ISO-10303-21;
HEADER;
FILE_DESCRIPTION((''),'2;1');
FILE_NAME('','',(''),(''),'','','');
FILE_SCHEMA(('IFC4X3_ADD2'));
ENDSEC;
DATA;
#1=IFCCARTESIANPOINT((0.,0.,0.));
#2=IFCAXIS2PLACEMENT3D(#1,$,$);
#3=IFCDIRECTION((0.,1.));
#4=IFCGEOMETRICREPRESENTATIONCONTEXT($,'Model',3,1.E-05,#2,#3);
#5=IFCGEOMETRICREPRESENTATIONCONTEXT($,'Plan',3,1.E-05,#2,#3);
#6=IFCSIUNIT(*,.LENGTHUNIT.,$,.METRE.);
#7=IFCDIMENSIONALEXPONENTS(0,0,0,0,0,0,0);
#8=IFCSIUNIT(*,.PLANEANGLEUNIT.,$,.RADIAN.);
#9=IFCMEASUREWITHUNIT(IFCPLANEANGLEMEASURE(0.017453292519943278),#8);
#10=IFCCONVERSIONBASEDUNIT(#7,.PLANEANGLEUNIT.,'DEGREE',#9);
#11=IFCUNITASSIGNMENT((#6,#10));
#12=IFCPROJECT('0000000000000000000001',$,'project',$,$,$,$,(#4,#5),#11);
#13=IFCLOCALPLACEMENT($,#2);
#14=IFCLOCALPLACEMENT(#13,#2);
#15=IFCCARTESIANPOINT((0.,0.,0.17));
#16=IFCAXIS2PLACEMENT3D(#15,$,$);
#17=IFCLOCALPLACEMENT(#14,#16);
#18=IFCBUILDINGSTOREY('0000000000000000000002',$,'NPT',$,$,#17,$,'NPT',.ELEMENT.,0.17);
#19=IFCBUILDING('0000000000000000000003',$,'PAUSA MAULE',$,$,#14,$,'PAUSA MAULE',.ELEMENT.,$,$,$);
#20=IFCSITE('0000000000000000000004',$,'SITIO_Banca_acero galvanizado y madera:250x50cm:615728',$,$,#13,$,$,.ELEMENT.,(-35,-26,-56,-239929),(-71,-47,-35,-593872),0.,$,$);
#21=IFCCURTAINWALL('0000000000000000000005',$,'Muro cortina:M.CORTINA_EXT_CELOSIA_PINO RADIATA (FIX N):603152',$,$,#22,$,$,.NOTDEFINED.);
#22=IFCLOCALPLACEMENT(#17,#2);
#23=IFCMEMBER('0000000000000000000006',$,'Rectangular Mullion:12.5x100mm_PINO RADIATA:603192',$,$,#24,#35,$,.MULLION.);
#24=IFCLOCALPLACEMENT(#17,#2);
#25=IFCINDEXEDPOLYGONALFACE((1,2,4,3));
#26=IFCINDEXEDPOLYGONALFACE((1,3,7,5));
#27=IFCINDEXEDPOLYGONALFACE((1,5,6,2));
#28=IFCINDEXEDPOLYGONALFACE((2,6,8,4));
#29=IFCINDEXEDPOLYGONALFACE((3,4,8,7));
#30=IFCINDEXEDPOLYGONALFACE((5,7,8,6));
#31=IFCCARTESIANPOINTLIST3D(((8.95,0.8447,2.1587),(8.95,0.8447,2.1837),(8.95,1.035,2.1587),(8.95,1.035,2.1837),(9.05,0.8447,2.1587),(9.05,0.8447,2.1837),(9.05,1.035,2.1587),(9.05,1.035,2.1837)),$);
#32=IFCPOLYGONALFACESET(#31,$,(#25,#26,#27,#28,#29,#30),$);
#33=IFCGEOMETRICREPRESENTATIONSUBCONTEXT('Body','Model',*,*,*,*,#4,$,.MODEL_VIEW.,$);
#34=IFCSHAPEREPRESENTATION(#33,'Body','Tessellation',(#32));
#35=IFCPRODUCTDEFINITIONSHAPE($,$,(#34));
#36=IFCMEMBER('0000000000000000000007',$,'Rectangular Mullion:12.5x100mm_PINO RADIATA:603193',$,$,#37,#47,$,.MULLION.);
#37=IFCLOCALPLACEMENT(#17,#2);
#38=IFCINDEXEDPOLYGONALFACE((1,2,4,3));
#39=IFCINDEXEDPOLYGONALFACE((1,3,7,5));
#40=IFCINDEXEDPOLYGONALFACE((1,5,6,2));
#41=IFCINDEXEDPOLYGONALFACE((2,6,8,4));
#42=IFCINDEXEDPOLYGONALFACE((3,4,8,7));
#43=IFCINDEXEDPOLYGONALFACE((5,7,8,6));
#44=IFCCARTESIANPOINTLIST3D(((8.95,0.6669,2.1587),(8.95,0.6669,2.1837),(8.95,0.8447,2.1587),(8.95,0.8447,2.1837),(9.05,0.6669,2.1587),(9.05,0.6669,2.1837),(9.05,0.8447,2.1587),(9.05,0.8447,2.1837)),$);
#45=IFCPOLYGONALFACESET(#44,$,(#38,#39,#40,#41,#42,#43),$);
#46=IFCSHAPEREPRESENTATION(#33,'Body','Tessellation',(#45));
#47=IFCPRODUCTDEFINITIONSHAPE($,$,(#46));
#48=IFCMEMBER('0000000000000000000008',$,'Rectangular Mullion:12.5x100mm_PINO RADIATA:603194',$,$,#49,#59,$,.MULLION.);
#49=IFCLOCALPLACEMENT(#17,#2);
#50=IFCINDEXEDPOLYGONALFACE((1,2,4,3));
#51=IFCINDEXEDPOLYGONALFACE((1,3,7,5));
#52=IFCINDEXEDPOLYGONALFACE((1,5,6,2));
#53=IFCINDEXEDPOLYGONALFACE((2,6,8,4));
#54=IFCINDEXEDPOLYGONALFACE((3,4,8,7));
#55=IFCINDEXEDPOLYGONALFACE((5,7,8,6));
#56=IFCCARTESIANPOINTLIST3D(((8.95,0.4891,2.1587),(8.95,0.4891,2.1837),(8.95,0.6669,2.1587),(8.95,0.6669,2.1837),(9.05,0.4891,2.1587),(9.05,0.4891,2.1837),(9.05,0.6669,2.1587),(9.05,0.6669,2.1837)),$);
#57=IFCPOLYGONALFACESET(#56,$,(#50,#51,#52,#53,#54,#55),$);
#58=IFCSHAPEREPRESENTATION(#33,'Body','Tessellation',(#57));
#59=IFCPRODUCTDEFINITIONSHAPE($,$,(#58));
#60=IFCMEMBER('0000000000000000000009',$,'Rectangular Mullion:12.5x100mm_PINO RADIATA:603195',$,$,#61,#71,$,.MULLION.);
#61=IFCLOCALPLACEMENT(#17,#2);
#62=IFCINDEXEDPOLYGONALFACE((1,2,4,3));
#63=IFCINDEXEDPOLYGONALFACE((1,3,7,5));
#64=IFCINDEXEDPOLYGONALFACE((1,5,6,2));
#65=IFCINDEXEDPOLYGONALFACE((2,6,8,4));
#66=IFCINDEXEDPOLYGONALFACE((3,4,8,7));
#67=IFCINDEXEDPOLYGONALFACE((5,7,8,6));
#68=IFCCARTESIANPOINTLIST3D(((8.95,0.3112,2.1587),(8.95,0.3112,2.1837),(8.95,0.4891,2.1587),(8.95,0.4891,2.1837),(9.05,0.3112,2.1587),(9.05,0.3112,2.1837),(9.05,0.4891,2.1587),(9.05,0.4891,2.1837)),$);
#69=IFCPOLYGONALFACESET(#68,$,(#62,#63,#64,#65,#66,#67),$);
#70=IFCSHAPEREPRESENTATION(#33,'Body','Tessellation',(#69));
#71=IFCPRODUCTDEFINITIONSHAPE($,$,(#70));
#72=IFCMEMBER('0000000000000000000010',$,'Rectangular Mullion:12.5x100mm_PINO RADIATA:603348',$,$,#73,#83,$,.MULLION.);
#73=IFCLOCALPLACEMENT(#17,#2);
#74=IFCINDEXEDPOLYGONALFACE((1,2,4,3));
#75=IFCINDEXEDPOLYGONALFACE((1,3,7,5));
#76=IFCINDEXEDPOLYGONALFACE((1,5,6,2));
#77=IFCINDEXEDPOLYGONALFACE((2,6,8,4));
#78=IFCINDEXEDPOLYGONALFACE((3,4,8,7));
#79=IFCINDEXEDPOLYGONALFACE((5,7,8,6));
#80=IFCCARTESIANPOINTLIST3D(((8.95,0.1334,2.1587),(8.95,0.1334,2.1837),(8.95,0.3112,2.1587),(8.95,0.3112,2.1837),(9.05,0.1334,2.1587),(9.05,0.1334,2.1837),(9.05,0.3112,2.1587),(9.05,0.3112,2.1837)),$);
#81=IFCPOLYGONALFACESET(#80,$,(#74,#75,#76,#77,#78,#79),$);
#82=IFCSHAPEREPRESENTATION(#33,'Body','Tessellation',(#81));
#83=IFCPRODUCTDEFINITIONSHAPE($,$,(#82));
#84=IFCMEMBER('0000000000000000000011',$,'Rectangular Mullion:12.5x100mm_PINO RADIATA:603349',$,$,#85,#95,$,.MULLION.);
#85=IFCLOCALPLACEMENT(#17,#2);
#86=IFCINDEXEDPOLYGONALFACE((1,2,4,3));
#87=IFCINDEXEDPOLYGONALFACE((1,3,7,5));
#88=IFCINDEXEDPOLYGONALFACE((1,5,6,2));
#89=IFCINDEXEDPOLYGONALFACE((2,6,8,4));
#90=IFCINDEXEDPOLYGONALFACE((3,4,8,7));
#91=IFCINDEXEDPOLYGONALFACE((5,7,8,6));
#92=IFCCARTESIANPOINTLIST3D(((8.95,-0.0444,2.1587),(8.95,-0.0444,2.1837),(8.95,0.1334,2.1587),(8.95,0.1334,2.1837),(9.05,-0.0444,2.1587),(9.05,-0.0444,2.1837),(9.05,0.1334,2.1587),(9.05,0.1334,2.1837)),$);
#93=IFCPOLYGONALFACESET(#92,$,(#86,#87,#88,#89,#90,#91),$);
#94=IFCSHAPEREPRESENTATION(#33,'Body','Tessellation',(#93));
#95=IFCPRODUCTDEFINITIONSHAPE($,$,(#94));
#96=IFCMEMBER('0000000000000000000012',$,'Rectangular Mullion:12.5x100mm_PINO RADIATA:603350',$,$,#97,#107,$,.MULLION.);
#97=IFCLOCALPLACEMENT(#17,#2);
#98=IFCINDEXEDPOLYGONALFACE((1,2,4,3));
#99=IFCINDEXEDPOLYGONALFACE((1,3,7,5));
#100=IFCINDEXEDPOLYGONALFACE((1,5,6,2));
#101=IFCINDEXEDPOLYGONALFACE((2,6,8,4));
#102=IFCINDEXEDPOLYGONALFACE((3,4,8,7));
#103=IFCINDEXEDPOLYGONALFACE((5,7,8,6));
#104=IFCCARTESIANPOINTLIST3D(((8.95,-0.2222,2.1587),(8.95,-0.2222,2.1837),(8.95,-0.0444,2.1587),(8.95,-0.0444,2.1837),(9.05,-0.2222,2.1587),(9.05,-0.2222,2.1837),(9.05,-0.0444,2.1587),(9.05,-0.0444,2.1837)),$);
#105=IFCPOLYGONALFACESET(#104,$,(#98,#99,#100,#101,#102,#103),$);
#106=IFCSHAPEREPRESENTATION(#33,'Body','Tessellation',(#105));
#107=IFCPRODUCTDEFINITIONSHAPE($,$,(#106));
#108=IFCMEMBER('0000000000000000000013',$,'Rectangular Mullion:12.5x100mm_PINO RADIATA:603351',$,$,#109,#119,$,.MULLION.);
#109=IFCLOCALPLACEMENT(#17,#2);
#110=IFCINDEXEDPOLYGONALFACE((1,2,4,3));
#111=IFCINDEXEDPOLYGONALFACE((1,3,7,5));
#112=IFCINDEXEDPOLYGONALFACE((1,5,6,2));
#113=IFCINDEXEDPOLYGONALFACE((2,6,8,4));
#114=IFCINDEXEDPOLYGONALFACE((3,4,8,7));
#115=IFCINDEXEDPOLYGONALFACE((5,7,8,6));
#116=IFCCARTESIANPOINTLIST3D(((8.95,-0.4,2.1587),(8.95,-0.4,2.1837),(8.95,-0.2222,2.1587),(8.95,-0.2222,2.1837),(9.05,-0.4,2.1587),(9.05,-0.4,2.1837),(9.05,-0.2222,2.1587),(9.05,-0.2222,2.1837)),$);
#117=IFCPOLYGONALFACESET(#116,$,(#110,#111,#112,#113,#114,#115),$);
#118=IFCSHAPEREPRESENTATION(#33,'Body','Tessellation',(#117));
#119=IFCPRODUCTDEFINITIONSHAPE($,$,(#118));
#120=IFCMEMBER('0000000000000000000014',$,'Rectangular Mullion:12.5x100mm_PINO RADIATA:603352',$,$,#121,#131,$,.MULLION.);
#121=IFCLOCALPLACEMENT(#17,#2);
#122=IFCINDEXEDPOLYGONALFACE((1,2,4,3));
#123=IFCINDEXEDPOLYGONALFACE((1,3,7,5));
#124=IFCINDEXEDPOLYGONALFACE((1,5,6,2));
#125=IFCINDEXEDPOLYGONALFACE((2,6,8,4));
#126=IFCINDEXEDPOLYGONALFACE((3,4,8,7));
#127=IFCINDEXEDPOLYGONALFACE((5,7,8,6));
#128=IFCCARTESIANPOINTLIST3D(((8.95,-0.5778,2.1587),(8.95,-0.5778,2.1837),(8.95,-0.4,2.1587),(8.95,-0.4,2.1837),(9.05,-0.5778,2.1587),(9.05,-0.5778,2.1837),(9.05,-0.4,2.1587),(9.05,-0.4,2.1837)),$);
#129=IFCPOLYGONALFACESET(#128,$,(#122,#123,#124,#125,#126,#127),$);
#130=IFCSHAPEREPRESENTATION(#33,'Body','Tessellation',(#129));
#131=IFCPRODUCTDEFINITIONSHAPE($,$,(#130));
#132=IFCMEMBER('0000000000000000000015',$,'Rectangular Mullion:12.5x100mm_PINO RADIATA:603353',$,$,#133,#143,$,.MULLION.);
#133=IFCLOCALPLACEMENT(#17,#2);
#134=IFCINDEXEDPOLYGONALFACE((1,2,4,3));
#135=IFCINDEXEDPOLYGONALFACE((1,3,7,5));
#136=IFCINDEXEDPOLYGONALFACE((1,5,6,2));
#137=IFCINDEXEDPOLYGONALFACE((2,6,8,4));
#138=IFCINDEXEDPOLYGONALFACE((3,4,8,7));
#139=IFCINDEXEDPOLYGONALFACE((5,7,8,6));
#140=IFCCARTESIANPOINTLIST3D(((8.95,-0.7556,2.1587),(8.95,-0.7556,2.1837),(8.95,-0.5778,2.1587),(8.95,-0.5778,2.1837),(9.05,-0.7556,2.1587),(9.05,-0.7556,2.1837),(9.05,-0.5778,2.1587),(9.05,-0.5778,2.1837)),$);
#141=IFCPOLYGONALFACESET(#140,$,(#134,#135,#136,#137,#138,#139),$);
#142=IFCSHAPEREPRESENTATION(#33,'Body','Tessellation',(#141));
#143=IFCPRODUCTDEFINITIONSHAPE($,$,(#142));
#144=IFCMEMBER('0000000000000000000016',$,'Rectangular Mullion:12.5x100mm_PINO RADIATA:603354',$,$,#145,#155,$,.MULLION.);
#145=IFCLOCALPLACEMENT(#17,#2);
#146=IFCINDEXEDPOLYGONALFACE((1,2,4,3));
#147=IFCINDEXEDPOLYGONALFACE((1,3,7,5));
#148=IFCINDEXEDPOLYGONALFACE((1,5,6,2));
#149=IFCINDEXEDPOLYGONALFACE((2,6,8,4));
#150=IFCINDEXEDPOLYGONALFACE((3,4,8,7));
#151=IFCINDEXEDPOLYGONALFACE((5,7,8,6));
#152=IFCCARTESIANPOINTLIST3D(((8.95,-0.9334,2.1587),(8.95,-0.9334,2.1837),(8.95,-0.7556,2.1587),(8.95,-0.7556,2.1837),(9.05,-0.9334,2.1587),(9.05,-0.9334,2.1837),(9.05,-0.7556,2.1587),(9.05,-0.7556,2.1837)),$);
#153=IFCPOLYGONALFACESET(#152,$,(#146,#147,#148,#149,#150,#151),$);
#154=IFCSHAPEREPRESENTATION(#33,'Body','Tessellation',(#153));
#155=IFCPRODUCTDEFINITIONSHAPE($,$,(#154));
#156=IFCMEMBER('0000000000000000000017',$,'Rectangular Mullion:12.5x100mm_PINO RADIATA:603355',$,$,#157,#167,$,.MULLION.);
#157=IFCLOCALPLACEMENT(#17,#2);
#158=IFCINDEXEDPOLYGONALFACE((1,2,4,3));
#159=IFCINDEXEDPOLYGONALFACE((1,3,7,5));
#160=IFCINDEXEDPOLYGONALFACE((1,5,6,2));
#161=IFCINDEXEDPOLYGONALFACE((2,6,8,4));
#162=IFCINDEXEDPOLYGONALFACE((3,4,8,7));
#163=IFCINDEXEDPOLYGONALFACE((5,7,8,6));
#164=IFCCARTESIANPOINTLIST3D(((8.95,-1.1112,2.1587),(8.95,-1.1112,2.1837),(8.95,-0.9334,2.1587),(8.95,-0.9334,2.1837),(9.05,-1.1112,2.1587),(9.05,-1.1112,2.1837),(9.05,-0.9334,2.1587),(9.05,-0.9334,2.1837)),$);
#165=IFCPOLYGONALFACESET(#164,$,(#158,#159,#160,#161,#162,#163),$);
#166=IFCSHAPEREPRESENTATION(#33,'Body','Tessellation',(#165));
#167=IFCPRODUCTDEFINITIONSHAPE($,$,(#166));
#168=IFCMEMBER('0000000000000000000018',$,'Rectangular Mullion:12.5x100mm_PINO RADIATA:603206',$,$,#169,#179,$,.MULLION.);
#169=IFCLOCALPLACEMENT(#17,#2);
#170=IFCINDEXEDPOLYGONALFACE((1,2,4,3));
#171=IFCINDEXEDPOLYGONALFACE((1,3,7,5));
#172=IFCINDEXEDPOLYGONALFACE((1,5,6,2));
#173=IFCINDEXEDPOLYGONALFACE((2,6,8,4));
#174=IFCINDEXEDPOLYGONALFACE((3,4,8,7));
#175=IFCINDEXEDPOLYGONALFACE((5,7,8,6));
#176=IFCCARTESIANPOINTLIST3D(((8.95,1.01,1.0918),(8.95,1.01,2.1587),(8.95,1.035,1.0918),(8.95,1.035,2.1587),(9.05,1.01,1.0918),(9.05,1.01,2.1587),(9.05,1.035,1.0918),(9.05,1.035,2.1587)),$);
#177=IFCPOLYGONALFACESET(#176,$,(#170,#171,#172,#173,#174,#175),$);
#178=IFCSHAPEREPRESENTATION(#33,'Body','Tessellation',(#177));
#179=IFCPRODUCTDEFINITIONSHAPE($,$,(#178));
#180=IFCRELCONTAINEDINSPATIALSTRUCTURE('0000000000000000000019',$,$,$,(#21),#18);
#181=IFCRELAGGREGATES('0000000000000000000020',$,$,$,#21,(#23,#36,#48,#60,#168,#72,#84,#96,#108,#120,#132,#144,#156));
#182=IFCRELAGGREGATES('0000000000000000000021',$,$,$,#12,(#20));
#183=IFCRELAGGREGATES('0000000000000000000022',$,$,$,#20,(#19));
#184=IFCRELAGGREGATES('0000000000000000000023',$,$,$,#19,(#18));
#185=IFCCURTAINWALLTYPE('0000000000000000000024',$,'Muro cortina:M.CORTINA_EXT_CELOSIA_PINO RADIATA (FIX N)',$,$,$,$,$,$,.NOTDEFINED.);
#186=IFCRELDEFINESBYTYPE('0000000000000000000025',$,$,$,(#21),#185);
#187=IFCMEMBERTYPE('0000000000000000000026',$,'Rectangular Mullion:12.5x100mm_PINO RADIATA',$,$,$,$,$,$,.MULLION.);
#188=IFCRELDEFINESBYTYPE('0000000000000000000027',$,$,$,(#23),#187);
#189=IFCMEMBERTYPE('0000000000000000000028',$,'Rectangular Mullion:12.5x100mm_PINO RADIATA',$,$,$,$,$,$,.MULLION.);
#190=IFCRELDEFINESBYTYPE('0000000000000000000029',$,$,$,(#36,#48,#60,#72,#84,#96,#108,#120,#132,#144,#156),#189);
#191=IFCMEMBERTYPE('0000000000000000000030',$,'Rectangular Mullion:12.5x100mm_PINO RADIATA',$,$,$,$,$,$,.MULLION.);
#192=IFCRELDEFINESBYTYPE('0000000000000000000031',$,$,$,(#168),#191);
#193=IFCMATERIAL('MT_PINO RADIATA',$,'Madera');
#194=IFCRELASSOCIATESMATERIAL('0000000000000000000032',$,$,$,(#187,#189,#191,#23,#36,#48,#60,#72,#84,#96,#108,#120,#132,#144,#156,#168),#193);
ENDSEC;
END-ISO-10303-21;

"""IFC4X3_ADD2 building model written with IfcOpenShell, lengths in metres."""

from ifc_helpers import new_model, entity, si_unit, converted_unit, direction, frame, frame_2d, origin, place, context, subcontext, project, spatial, rectangle, extrude, source, transform, mapped, material, material_profile, profile_set, profile_usage, type_object, type_shapes, element, aggregate, save


model = new_model("IFC4X3_ADD2")

# Units and contexts
model_context = context("Model", 3, precision=1e-05, world=origin(), true_north=direction((0.0, 1.0)))
plan_context = context("Plan", 3, precision=1e-05, world=origin(), true_north=direction((0.0, 1.0)))
body_context = subcontext(model_context, "Body", "Model", "MODEL_VIEW")
ifc_project = project(units=[si_unit("LENGTHUNIT", "METRE"), converted_unit("PLANEANGLEUNIT", "DEGREE", entity("IfcPlaneAngleMeasure", 0.017453292519943278), si_unit("PLANEANGLEUNIT", "RADIAN"), dimensions=[0, 0, 0, 0, 0, 0, 0])], contexts=[model_context, plan_context])

# Site, building, storey
site_placement = place(None, origin())
site = spatial("IfcSite", under=ifc_project, at=site_placement, Name="SITIO_Banca_acero galvanizado y madera:250x50cm:615728", CompositionType="ELEMENT", RefLatitude=(-35, -26, -56, -239929), RefLongitude=(-71, -47, -35, -593872), RefElevation=0.0)
building_placement = place(site_placement, origin())
building = spatial("IfcBuilding", under=site, at=building_placement, Name="PAUSA MAULE", LongName="PAUSA MAULE", CompositionType="ELEMENT")
storey_placement = place(building_placement, frame((0.0, 0.0, 0.17)))
storey = spatial("IfcBuildingStorey", under=building, at=storey_placement, Name="NPT", LongName="NPT", CompositionType="ELEMENT", Elevation=0.17)

# Curtain wall, members
curtain_wall_type = type_object("IfcCurtainWallType", Name="Muro cortina:M.CORTINA_EXT_CELOSIA_PINO RADIATA (FIX N)", PredefinedType="NOTDEFINED")
curtain_wall_placement = place(storey_placement, frame((0.0, 0.0, -0.17)))
curtain_wall = element("IfcCurtainWall", 1, at=curtain_wall_placement, inside=storey, type_object=curtain_wall_type, Name="Muro cortina:M.CORTINA_EXT_CELOSIA_PINO RADIATA (FIX N):603152", PredefinedType="NOTDEFINED")
ifc_material = material(Name="MT_PINO RADIATA", Category="Madera")
ifc_material_profile = material_profile(ifc_material, rectangle(XDim=0.025, YDim=0.1, at=frame_2d((0.0, 0.0), x_axis=(1.0, 0.0))), Name="12.5x100mm_PINO RADIATA")
ifc_profile_set = profile_set([ifc_material_profile], Name="12.5x100mm_PINO RADIATA")
ifc_profile_usage = profile_usage(ifc_profile_set)
member_type_1 = type_object("IfcMemberType", Name="Rectangular Mullion:12.5x100mm_PINO RADIATA", PredefinedType="MULLION", material=ifc_profile_set)
shared_shape_1 = source(origin(), body_context, "Body", "SweptSolid", [
    extrude(rectangle(XDim=0.025, YDim=0.1, at=frame_2d((0.0, 0.0), x_axis=(1.0, 0.0))), frame((-0.0125, 0.0, -0.1903), z_axis=(0.0, 0.0, 1.0), x_axis=(-1.0, 0.0, 0.0)), (0.0, 0.0, 1.0), 0.1903),
])
type_shapes(member_type_1, [shared_shape_1])
member_1_placement = place(curtain_wall_placement, frame((9.0, 0.8447, 2.3537), z_axis=(0.0, -1.0, 0.0), x_axis=(0.0, 0.0, 1.0)))
member_1 = element("IfcMember", 2, at=member_1_placement, type_object=member_type_1, material=ifc_profile_usage, Name="Rectangular Mullion:12.5x100mm_PINO RADIATA:603192", PredefinedType="MULLION", context=body_context, shape_type="MappedRepresentation", body=[
    mapped(shared_shape_1, transform((0.0, 0.0, 0.0), scale=1.0)),
])
member_type_2 = type_object("IfcMemberType", Name="Rectangular Mullion:12.5x100mm_PINO RADIATA", PredefinedType="MULLION", material=ifc_profile_set)
shared_shape_2 = source(origin(), body_context, "Body", "SweptSolid", [
    extrude(rectangle(XDim=0.025, YDim=0.1, at=frame_2d((0.0, 0.0), x_axis=(1.0, 0.0))), frame((-0.0125, 0.0, -0.1778), z_axis=(0.0, 0.0, 1.0), x_axis=(-1.0, 0.0, 0.0)), (0.0, 0.0, 1.0), 0.1778),
])
type_shapes(member_type_2, [shared_shape_2])
member_2_placement = place(curtain_wall_placement, frame((9.0, 0.6669, 2.3537), z_axis=(0.0, -1.0, 0.0), x_axis=(0.0, 0.0, 1.0)))
member_2 = element("IfcMember", 3, at=member_2_placement, type_object=member_type_2, material=ifc_profile_usage, Name="Rectangular Mullion:12.5x100mm_PINO RADIATA:603193", PredefinedType="MULLION", context=body_context, shape_type="MappedRepresentation", body=[
    mapped(shared_shape_2, transform((0.0, 0.0, 0.0), scale=1.0)),
])
member_3_placement = place(curtain_wall_placement, frame((9.0, 0.4891, 2.3537), z_axis=(0.0, -1.0, 0.0), x_axis=(0.0, 0.0, 1.0)))
member_3 = element("IfcMember", 4, at=member_3_placement, type_object=member_type_2, material=ifc_profile_usage, Name="Rectangular Mullion:12.5x100mm_PINO RADIATA:603194", PredefinedType="MULLION", context=body_context, shape_type="MappedRepresentation", body=[
    mapped(shared_shape_2, transform((0.0, 0.0, 0.0), scale=1.0)),
])
member_4_placement = place(curtain_wall_placement, frame((9.0, 0.3112, 2.3537), z_axis=(0.0, -1.0, 0.0), x_axis=(0.0, 0.0, 1.0)))
member_4 = element("IfcMember", 5, at=member_4_placement, type_object=member_type_2, material=ifc_profile_usage, Name="Rectangular Mullion:12.5x100mm_PINO RADIATA:603195", PredefinedType="MULLION", context=body_context, shape_type="MappedRepresentation", body=[
    mapped(shared_shape_2, transform((0.0, 0.0, 0.0), scale=1.0)),
])
member_5_placement = place(curtain_wall_placement, frame((9.0, 0.1334, 2.3537), z_axis=(0.0, -1.0, 0.0), x_axis=(0.0, 0.0, 1.0)))
member_5 = element("IfcMember", 6, at=member_5_placement, type_object=member_type_2, material=ifc_profile_usage, Name="Rectangular Mullion:12.5x100mm_PINO RADIATA:603348", PredefinedType="MULLION", context=body_context, shape_type="MappedRepresentation", body=[
    mapped(shared_shape_2, transform((0.0, 0.0, 0.0), scale=1.0)),
])
member_6_placement = place(curtain_wall_placement, frame((9.0, -0.0444, 2.3537), z_axis=(0.0, -1.0, 0.0), x_axis=(0.0, 0.0, 1.0)))
member_6 = element("IfcMember", 7, at=member_6_placement, type_object=member_type_2, material=ifc_profile_usage, Name="Rectangular Mullion:12.5x100mm_PINO RADIATA:603349", PredefinedType="MULLION", context=body_context, shape_type="MappedRepresentation", body=[
    mapped(shared_shape_2, transform((0.0, 0.0, 0.0), scale=1.0)),
])
member_7_placement = place(curtain_wall_placement, frame((9.0, -0.2222, 2.3537), z_axis=(0.0, -1.0, 0.0), x_axis=(0.0, 0.0, 1.0)))
member_7 = element("IfcMember", 8, at=member_7_placement, type_object=member_type_2, material=ifc_profile_usage, Name="Rectangular Mullion:12.5x100mm_PINO RADIATA:603350", PredefinedType="MULLION", context=body_context, shape_type="MappedRepresentation", body=[
    mapped(shared_shape_2, transform((0.0, 0.0, 0.0), scale=1.0)),
])
member_8_placement = place(curtain_wall_placement, frame((9.0, -0.4, 2.3537), z_axis=(0.0, -1.0, 0.0), x_axis=(0.0, 0.0, 1.0)))
member_8 = element("IfcMember", 9, at=member_8_placement, type_object=member_type_2, material=ifc_profile_usage, Name="Rectangular Mullion:12.5x100mm_PINO RADIATA:603351", PredefinedType="MULLION", context=body_context, shape_type="MappedRepresentation", body=[
    mapped(shared_shape_2, transform((0.0, 0.0, 0.0), scale=1.0)),
])
member_9_placement = place(curtain_wall_placement, frame((9.0, -0.5778, 2.3537), z_axis=(0.0, -1.0, 0.0), x_axis=(0.0, 0.0, 1.0)))
member_9 = element("IfcMember", 10, at=member_9_placement, type_object=member_type_2, material=ifc_profile_usage, Name="Rectangular Mullion:12.5x100mm_PINO RADIATA:603352", PredefinedType="MULLION", context=body_context, shape_type="MappedRepresentation", body=[
    mapped(shared_shape_2, transform((0.0, 0.0, 0.0), scale=1.0)),
])
member_10_placement = place(curtain_wall_placement, frame((9.0, -0.7556, 2.3537), z_axis=(0.0, -1.0, 0.0), x_axis=(0.0, 0.0, 1.0)))
member_10 = element("IfcMember", 11, at=member_10_placement, type_object=member_type_2, material=ifc_profile_usage, Name="Rectangular Mullion:12.5x100mm_PINO RADIATA:603353", PredefinedType="MULLION", context=body_context, shape_type="MappedRepresentation", body=[
    mapped(shared_shape_2, transform((0.0, 0.0, 0.0), scale=1.0)),
])
member_11_placement = place(curtain_wall_placement, frame((9.0, -0.9334, 2.3537), z_axis=(0.0, -1.0, 0.0), x_axis=(0.0, 0.0, 1.0)))
member_11 = element("IfcMember", 12, at=member_11_placement, type_object=member_type_2, material=ifc_profile_usage, Name="Rectangular Mullion:12.5x100mm_PINO RADIATA:603354", PredefinedType="MULLION", context=body_context, shape_type="MappedRepresentation", body=[
    mapped(shared_shape_2, transform((0.0, 0.0, 0.0), scale=1.0)),
])
member_12_placement = place(curtain_wall_placement, frame((9.0, -1.1112, 2.3537), z_axis=(0.0, -1.0, 0.0), x_axis=(0.0, 0.0, 1.0)))
member_12 = element("IfcMember", 13, at=member_12_placement, type_object=member_type_2, material=ifc_profile_usage, Name="Rectangular Mullion:12.5x100mm_PINO RADIATA:603355", PredefinedType="MULLION", context=body_context, shape_type="MappedRepresentation", body=[
    mapped(shared_shape_2, transform((0.0, 0.0, 0.0), scale=1.0)),
])
member_type_3 = type_object("IfcMemberType", Name="Rectangular Mullion:12.5x100mm_PINO RADIATA", PredefinedType="MULLION", material=ifc_profile_set)
shared_shape_3 = source(origin(), body_context, "Body", "SweptSolid", [
    extrude(rectangle(XDim=0.025, YDim=0.1, at=frame_2d((0.0, 0.0), x_axis=(1.0, 0.0))), frame((-0.0125, 0.0, -1.0668), z_axis=(0.0, 0.0, 1.0), x_axis=(-1.0, 0.0, 0.0)), (0.0, 0.0, 1.0), 1.0668),
])
type_shapes(member_type_3, [shared_shape_3])
member_13_placement = place(curtain_wall_placement, frame((9.0, 1.035, 2.3287), z_axis=(0.0, 0.0, 1.0), x_axis=(0.0, 1.0, 0.0)))
member_13 = element("IfcMember", 14, at=member_13_placement, type_object=member_type_3, material=ifc_profile_usage, Name="Rectangular Mullion:12.5x100mm_PINO RADIATA:603206", PredefinedType="MULLION", context=body_context, shape_type="MappedRepresentation", body=[
    mapped(shared_shape_3, transform((0.0, 0.0, 0.0), scale=1.0)),
])
aggregate(curtain_wall, [member_1, member_2, member_3, member_4, member_13, member_5, member_6, member_7, member_8, member_9, member_10, member_11, member_12])

save(model, "model.ifc")
